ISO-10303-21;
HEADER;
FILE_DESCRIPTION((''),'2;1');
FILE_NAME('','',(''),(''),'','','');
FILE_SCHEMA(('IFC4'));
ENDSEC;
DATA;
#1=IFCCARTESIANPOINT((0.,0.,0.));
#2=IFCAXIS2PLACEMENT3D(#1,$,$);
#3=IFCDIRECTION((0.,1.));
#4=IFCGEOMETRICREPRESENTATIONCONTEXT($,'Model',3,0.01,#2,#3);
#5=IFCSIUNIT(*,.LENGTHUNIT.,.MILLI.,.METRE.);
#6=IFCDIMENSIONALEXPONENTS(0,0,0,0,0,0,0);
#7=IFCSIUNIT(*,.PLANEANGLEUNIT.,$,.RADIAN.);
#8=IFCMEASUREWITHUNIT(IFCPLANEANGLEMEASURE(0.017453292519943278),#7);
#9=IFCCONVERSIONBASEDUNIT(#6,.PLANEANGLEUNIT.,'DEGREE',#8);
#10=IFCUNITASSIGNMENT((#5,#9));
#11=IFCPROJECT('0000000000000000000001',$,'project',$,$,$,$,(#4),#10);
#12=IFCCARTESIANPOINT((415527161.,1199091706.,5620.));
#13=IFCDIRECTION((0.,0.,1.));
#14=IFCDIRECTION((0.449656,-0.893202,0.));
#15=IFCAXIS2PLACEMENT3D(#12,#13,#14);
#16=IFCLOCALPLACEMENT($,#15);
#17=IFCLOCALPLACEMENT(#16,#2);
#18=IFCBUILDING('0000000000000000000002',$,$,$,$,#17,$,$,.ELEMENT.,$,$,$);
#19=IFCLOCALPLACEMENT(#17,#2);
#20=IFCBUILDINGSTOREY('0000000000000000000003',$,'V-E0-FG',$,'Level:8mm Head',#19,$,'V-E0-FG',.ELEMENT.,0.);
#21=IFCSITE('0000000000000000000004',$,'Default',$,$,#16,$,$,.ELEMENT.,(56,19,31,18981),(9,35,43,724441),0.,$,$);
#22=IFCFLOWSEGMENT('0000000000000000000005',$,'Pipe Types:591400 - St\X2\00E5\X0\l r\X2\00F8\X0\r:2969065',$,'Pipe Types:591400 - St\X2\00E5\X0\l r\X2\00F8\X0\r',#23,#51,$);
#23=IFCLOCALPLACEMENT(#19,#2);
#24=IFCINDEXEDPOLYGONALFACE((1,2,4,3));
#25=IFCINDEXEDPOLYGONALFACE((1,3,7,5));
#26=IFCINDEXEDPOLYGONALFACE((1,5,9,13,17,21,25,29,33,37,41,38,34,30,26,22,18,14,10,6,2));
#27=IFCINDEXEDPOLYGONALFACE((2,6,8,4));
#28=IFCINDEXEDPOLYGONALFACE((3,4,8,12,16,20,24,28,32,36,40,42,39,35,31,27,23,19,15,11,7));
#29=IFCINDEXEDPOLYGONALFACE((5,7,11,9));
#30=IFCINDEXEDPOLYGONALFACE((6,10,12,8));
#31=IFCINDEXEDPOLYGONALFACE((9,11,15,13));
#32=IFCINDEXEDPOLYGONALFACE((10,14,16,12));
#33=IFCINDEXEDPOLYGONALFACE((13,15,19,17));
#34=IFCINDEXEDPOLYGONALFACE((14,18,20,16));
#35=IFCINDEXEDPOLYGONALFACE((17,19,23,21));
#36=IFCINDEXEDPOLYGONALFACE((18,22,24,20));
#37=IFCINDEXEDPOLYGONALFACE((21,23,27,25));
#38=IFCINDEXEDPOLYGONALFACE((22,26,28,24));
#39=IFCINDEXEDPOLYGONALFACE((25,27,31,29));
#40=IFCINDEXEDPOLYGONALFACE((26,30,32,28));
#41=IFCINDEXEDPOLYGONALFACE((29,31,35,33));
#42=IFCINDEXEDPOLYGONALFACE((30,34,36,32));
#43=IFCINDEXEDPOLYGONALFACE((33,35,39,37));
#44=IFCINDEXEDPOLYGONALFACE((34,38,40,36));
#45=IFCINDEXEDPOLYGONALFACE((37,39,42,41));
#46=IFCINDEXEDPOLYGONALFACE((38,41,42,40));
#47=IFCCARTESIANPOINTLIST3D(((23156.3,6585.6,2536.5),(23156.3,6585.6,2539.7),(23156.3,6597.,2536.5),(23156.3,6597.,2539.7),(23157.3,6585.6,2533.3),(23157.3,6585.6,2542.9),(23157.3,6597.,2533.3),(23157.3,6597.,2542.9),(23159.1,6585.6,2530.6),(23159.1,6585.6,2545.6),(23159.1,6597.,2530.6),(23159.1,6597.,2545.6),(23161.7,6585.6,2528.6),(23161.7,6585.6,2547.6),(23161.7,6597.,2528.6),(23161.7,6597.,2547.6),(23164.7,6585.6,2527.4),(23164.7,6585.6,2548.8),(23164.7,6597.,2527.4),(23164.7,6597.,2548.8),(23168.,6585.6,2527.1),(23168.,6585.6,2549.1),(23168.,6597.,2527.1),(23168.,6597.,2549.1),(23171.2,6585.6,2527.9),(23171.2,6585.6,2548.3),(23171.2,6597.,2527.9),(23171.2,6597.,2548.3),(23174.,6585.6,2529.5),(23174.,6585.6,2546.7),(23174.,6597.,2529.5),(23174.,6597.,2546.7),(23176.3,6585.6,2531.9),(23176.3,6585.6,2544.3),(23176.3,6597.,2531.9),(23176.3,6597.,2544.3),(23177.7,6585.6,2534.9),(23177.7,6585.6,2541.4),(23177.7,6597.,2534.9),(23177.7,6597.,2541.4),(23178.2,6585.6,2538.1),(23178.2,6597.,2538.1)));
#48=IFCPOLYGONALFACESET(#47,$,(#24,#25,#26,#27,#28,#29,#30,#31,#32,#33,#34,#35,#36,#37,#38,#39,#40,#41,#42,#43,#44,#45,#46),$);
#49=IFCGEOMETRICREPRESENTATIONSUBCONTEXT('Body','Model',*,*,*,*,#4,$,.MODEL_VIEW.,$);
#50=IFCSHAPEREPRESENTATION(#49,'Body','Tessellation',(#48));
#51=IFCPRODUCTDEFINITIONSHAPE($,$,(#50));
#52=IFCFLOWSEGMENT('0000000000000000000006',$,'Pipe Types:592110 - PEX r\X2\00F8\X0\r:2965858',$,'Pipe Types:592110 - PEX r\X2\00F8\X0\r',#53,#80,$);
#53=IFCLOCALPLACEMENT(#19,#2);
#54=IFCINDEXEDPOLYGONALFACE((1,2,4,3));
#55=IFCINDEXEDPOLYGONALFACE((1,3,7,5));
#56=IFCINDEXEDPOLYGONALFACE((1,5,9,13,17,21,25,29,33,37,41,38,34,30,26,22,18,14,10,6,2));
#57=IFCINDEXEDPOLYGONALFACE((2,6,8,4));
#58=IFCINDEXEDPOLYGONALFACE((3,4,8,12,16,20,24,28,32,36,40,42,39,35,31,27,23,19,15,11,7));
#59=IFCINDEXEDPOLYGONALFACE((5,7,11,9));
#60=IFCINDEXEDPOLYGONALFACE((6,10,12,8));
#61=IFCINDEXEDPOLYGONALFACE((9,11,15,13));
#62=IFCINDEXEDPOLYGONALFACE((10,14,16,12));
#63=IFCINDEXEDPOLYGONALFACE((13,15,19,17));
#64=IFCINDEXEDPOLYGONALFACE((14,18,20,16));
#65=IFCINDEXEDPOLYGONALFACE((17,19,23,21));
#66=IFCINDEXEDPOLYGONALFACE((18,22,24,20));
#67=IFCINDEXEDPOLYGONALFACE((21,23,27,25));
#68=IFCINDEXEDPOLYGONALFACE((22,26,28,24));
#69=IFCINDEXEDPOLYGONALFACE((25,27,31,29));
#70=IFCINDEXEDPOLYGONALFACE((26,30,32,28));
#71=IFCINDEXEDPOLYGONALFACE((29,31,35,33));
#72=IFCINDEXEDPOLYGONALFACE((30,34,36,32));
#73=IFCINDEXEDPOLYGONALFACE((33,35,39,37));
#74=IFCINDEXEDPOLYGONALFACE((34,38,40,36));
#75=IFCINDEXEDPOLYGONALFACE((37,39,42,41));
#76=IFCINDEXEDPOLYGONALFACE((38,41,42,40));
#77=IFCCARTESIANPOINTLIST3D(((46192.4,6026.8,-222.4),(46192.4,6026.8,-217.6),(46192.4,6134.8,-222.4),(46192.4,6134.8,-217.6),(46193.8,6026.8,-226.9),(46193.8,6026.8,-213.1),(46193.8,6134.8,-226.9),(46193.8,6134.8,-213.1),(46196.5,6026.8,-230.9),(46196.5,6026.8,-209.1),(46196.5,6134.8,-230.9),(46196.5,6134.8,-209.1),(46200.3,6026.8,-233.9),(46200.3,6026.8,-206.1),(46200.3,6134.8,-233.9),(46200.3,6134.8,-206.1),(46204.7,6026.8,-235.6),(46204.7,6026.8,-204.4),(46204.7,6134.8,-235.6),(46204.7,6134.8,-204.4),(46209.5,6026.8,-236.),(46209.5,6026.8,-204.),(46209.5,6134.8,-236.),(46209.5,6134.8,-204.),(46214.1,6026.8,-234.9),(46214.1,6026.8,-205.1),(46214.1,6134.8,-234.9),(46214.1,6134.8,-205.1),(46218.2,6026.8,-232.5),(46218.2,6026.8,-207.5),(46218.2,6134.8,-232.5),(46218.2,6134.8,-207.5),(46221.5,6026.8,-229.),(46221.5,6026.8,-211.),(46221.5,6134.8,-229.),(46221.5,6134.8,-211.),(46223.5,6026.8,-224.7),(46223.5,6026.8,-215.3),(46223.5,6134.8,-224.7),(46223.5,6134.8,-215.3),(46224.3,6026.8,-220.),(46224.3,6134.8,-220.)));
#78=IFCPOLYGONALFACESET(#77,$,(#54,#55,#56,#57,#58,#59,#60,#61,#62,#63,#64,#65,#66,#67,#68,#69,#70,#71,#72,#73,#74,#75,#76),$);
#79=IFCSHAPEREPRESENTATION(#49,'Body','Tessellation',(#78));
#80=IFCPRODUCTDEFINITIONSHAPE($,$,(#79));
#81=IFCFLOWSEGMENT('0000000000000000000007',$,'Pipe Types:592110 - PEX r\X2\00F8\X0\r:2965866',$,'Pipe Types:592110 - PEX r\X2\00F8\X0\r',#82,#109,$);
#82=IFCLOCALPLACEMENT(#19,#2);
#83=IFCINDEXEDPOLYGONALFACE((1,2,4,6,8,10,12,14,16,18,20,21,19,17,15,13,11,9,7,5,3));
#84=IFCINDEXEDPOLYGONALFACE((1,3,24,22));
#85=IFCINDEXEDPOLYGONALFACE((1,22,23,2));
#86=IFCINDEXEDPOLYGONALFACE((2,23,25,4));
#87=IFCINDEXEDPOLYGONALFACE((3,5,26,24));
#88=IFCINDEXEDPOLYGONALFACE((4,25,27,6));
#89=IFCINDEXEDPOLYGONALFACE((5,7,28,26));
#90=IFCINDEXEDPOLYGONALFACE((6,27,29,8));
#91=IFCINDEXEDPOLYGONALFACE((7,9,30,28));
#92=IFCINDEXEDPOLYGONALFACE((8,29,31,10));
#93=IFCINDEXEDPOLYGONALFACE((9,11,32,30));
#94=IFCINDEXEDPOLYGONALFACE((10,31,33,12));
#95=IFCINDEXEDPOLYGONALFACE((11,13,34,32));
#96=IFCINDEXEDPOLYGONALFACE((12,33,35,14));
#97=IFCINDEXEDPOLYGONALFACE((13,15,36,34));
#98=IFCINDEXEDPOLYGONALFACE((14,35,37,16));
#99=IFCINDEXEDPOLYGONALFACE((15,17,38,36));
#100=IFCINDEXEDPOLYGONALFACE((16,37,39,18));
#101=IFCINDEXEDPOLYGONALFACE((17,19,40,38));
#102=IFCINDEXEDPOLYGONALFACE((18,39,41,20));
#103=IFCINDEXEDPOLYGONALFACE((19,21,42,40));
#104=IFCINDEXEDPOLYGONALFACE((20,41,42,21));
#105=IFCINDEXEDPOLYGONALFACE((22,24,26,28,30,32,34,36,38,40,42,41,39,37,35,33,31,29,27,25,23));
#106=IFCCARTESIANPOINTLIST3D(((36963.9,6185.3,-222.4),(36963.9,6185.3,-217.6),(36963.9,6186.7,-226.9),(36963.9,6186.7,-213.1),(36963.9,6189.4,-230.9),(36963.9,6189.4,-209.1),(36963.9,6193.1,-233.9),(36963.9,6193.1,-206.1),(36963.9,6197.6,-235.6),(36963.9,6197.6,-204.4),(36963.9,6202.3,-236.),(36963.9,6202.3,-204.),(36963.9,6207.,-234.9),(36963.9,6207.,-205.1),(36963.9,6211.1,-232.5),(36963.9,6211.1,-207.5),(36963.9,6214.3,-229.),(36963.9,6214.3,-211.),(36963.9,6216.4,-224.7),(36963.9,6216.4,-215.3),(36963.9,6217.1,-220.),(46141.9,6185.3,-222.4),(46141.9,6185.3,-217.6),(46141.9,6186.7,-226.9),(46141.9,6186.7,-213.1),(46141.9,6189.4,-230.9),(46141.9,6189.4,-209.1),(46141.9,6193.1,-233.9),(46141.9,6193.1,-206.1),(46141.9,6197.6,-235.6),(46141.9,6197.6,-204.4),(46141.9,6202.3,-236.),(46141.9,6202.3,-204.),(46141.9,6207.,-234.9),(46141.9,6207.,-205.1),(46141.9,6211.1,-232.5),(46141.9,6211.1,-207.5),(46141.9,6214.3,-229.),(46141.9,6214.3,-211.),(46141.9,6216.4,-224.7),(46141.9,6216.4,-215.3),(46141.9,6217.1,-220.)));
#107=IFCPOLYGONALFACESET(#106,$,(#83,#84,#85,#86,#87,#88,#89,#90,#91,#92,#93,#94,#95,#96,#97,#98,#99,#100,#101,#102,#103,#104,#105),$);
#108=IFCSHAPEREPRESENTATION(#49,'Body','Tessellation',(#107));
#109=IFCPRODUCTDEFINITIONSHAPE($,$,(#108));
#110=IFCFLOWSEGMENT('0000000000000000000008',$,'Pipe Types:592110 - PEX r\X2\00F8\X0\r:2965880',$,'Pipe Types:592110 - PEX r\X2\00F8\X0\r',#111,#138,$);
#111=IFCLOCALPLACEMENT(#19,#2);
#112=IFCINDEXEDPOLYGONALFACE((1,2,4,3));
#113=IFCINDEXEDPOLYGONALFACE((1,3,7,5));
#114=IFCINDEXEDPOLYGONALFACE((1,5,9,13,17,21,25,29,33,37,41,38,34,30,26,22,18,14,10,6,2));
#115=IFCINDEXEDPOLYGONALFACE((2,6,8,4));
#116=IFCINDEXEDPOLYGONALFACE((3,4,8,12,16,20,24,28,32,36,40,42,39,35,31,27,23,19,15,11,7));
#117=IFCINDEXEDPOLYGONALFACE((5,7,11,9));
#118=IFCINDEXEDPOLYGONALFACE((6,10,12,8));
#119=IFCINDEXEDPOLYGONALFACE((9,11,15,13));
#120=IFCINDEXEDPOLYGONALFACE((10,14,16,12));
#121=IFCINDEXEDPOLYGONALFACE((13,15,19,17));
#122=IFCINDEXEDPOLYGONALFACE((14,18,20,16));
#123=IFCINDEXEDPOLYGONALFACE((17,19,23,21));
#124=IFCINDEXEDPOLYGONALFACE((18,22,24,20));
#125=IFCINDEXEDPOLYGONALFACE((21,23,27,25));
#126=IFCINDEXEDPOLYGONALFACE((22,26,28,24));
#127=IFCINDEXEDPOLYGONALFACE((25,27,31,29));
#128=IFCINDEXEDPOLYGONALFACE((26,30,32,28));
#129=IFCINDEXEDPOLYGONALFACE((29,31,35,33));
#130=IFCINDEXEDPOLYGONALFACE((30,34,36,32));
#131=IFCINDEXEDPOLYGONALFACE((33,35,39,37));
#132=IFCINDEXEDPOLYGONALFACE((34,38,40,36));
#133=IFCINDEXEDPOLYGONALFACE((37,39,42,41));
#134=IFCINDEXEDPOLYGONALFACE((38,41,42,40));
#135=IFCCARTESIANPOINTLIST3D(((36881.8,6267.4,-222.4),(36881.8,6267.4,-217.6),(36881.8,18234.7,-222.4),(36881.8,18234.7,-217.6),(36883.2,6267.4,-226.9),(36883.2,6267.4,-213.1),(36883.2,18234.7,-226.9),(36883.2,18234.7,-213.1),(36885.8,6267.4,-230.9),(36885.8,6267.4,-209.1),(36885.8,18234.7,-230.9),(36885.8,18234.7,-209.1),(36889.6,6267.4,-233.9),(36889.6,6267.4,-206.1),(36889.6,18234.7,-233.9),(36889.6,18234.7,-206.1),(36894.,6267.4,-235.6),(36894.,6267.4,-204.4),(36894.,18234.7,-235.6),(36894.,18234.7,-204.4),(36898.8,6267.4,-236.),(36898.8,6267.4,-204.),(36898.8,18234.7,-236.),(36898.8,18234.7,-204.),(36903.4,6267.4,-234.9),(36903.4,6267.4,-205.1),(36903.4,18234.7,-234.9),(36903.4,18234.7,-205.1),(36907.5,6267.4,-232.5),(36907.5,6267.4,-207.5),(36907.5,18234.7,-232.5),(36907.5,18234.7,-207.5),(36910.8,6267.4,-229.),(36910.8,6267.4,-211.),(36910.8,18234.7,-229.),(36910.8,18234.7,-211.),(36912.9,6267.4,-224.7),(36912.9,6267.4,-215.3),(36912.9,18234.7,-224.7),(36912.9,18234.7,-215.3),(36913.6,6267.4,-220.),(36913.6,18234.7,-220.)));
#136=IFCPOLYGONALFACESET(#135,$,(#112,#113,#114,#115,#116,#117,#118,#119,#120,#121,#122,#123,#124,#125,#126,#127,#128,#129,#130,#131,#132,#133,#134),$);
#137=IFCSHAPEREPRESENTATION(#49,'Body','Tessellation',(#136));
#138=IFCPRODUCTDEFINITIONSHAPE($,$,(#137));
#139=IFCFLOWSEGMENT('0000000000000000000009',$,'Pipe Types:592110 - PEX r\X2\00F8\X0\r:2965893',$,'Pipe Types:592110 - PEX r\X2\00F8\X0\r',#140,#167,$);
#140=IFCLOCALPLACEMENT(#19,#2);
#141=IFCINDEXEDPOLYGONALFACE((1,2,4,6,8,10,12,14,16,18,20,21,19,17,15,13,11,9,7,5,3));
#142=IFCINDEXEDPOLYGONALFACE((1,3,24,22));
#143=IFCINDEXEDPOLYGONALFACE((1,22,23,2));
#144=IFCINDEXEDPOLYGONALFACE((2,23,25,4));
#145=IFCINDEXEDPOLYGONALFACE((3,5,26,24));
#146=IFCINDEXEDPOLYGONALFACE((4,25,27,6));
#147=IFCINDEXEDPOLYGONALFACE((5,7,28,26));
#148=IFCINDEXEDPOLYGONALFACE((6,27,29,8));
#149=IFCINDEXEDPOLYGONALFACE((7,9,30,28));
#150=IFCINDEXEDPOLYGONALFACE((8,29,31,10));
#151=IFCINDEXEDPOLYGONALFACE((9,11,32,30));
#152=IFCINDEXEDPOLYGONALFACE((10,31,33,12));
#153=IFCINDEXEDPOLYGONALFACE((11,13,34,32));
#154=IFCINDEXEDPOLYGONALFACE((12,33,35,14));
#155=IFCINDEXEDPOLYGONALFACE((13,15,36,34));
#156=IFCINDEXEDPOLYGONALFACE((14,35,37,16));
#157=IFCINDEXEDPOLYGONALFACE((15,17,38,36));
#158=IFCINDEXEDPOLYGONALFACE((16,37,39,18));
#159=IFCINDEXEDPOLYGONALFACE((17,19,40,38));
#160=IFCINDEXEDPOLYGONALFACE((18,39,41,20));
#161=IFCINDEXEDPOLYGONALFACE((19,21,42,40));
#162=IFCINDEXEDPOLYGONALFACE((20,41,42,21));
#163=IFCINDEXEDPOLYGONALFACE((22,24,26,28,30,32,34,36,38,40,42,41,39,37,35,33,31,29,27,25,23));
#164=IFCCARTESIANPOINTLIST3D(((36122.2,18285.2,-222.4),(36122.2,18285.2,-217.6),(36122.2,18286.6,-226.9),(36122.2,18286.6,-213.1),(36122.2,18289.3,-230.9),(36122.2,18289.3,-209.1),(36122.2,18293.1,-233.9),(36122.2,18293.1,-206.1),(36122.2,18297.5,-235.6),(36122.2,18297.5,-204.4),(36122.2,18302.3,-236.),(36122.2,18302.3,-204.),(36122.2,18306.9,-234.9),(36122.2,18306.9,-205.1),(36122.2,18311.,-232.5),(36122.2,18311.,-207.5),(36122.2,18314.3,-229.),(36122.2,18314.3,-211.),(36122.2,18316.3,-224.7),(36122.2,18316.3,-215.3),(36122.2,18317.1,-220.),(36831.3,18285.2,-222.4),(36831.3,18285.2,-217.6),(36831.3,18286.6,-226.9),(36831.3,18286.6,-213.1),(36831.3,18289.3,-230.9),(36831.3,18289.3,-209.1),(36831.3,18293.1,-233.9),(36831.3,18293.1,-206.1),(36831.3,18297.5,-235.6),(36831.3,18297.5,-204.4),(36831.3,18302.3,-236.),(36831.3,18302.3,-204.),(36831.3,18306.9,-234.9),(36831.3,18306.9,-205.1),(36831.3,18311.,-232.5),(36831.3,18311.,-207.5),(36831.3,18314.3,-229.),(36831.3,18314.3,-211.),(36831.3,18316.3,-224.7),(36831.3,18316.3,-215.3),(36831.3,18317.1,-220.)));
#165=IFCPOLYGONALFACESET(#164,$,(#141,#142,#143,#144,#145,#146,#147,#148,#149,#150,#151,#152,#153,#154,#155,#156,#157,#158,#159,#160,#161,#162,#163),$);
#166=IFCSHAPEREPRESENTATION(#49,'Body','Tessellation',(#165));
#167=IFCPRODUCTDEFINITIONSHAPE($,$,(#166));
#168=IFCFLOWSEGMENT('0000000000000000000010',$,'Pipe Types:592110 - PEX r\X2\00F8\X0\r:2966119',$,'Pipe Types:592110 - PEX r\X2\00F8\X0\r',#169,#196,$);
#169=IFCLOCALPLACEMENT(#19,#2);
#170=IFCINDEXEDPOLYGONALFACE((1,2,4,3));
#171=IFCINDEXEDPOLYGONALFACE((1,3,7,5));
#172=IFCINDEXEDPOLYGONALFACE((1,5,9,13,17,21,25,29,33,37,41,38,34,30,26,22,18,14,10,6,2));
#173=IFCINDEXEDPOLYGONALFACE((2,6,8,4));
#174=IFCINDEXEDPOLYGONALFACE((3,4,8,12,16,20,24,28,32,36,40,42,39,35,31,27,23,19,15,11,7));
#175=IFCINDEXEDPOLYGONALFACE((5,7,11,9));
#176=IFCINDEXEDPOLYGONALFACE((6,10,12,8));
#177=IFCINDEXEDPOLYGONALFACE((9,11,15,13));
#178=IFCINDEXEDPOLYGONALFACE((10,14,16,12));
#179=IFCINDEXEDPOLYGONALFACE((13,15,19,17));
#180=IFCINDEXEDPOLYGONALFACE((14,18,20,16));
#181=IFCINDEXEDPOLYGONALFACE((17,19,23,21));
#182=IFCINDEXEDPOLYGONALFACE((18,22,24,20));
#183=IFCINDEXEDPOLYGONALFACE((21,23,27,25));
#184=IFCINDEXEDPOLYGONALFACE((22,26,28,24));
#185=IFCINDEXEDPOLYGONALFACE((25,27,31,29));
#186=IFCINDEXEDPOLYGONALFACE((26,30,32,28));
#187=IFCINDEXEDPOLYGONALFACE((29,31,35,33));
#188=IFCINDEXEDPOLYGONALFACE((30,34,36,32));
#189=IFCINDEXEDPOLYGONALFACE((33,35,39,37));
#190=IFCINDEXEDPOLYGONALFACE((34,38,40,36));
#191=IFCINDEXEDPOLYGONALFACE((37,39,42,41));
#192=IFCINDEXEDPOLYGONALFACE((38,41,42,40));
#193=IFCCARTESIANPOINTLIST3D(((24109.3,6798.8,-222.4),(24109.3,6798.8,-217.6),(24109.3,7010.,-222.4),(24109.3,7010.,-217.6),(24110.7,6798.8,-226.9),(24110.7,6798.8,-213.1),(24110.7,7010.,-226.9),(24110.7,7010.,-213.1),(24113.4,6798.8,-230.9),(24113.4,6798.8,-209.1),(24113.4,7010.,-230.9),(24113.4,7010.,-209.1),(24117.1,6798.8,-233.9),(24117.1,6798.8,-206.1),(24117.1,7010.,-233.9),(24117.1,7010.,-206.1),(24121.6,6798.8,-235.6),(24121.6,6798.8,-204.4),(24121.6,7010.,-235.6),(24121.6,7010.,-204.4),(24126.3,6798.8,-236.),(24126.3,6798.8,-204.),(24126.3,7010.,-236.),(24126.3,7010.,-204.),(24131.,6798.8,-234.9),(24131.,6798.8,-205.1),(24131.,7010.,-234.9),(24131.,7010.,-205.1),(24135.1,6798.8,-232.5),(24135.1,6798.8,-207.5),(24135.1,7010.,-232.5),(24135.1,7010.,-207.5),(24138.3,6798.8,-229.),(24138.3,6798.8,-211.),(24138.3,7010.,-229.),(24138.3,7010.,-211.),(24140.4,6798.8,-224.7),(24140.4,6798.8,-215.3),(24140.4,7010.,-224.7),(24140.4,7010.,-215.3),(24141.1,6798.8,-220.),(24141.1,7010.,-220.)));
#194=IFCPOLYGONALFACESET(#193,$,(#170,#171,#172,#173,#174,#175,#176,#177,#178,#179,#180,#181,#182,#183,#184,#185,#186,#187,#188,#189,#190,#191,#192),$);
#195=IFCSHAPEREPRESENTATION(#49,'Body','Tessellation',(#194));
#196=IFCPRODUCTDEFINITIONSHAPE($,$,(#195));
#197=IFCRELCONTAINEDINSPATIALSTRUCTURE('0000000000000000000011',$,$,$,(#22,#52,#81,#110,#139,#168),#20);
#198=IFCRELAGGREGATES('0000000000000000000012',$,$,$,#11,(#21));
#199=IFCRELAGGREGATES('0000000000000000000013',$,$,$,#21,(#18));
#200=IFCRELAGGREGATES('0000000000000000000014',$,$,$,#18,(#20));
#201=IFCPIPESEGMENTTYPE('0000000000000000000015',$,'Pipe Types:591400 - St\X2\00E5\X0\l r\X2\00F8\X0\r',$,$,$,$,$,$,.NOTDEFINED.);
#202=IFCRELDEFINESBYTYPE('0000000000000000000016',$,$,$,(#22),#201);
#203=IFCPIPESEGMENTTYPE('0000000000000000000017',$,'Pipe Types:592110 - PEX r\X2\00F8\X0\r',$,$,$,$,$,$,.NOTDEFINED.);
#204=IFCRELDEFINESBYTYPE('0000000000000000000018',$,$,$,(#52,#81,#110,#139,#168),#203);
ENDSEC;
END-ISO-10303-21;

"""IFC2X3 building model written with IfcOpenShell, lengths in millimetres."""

from ifc_helpers import new_model, entity, si_unit, converted_unit, direction, frame, frame_2d, origin, origin_2d_with_axis, place, context, subcontext, project, spatial, circle, extrude, type_object, element, save


model = new_model("IFC2X3")

# Units and contexts
model_context = context("Model", 3, precision=0.01, world=origin(), true_north=direction((0.0, 1.0)))
body_context = subcontext(model_context, "Body", "Model", "MODEL_VIEW")
ifc_project = project(units=[si_unit("LENGTHUNIT", "METRE", prefix="MILLI"), converted_unit("PLANEANGLEUNIT", "DEGREE", entity("IfcPlaneAngleMeasure", 0.017453292519943278), si_unit("PLANEANGLEUNIT", "RADIAN"), dimensions=[0, 0, 0, 0, 0, 0, 0])], contexts=[model_context])

# Site, building, storey
site_placement = place(None, frame((415527161.0, 1199091706.0, 5620.0), z_axis=(0.0, 0.0, 1.0), x_axis=(0.449656, -0.893202, 0.0)))
site = spatial("IfcSite", under=ifc_project, at=site_placement, Name="Default", CompositionType="ELEMENT", RefLatitude=(56, 19, 31, 18981), RefLongitude=(9, 35, 43, 724441), RefElevation=0.0)
building_placement = place(site_placement, origin())
building = spatial("IfcBuilding", under=site, at=building_placement, CompositionType="ELEMENT")
storey_placement = place(building_placement, origin())
storey = spatial("IfcBuildingStorey", under=building, at=storey_placement, Name="V-E0-FG", ObjectType="Level:8mm Head", LongName="V-E0-FG", CompositionType="ELEMENT", Elevation=0.0)

# Flow segments
pipe_segment_type_1 = type_object("IfcPipeSegmentType", Name="Pipe Types:591400 - Stål rør", PredefinedType="NOTDEFINED")
flow_segment_1_placement = place(storey_placement, origin())
element("IfcFlowSegment", 1, at=flow_segment_1_placement, inside=storey, type_object=pipe_segment_type_1, Name="Pipe Types:591400 - Stål rør:2969065", ObjectType="Pipe Types:591400 - Stål rør", context=body_context, shape_type="SweptSolid", body=[
    extrude(circle(Radius=11.0, at=frame_2d((0.0, 0.0), x_axis=(1.0, 0.0))), frame((23167.2, 6585.6, 2538.1), z_axis=(0.0, 1.0, 0.0), x_axis=(1.0, 0.0, 0.0)), (0.0, 0.0, 1.0), 11.4),
])
pipe_segment_type_2 = type_object("IfcPipeSegmentType", Name="Pipe Types:592110 - PEX rør", PredefinedType="NOTDEFINED")
flow_segment_2_placement = place(storey_placement, origin())
element("IfcFlowSegment", 2, at=flow_segment_2_placement, inside=storey, type_object=pipe_segment_type_2, Name="Pipe Types:592110 - PEX rør:2965858", ObjectType="Pipe Types:592110 - PEX rør", context=body_context, shape_type="SweptSolid", body=[
    extrude(circle(Radius=16.0, at=frame_2d((0.0, 0.0), x_axis=(1.0, 0.0))), frame((46208.3, 6026.8, -220.0), z_axis=(0.0, 1.0, 0.0), x_axis=(1.0, 0.0, 0.0)), (0.0, 0.0, 1.0), 108.0),
])
flow_segment_3_placement = place(storey_placement, origin())
element("IfcFlowSegment", 3, at=flow_segment_3_placement, inside=storey, type_object=pipe_segment_type_2, Name="Pipe Types:592110 - PEX rør:2965866", ObjectType="Pipe Types:592110 - PEX rør", context=body_context, shape_type="SweptSolid", body=[
    extrude(circle(Radius=16.0, at=origin_2d_with_axis()), frame((36963.9, 6201.1, -220.0), z_axis=(1.0, 0.0, 0.0), x_axis=(0.0, 1.0, 0.0)), (0.0, 0.0, 1.0), 9178.0),
])
flow_segment_4_placement = place(storey_placement, origin())
element("IfcFlowSegment", 4, at=flow_segment_4_placement, inside=storey, type_object=pipe_segment_type_2, Name="Pipe Types:592110 - PEX rør:2965880", ObjectType="Pipe Types:592110 - PEX rør", context=body_context, shape_type="SweptSolid", body=[
    extrude(circle(Radius=16.0, at=origin_2d_with_axis()), frame((36897.6, 6267.4, -220.0), z_axis=(0.0, 1.0, 0.0), x_axis=(1.0, 0.0, 0.0)), (0.0, 0.0, 1.0), 11967.3),
])
flow_segment_5_placement = place(storey_placement, origin())
element("IfcFlowSegment", 5, at=flow_segment_5_placement, inside=storey, type_object=pipe_segment_type_2, Name="Pipe Types:592110 - PEX rør:2965893", ObjectType="Pipe Types:592110 - PEX rør", context=body_context, shape_type="SweptSolid", body=[
    extrude(circle(Radius=16.0, at=origin_2d_with_axis()), frame((36122.2, 18301.1, -220.0), z_axis=(1.0, 0.0, 0.0), x_axis=(0.0, 1.0, 0.0)), (0.0, 0.0, 1.0), 709.0),
])
flow_segment_6_placement = place(storey_placement, origin())
element("IfcFlowSegment", 6, at=flow_segment_6_placement, inside=storey, type_object=pipe_segment_type_2, Name="Pipe Types:592110 - PEX rør:2966119", ObjectType="Pipe Types:592110 - PEX rør", context=body_context, shape_type="SweptSolid", body=[
    extrude(circle(Radius=16.0, at=origin_2d_with_axis()), frame((24125.1, 6798.8, -220.0), z_axis=(0.0, 1.0, 0.0), x_axis=(1.0, 0.0, 0.0)), (0.0, 0.0, 1.0), 211.2),
])

save(model, "model.ifc")
